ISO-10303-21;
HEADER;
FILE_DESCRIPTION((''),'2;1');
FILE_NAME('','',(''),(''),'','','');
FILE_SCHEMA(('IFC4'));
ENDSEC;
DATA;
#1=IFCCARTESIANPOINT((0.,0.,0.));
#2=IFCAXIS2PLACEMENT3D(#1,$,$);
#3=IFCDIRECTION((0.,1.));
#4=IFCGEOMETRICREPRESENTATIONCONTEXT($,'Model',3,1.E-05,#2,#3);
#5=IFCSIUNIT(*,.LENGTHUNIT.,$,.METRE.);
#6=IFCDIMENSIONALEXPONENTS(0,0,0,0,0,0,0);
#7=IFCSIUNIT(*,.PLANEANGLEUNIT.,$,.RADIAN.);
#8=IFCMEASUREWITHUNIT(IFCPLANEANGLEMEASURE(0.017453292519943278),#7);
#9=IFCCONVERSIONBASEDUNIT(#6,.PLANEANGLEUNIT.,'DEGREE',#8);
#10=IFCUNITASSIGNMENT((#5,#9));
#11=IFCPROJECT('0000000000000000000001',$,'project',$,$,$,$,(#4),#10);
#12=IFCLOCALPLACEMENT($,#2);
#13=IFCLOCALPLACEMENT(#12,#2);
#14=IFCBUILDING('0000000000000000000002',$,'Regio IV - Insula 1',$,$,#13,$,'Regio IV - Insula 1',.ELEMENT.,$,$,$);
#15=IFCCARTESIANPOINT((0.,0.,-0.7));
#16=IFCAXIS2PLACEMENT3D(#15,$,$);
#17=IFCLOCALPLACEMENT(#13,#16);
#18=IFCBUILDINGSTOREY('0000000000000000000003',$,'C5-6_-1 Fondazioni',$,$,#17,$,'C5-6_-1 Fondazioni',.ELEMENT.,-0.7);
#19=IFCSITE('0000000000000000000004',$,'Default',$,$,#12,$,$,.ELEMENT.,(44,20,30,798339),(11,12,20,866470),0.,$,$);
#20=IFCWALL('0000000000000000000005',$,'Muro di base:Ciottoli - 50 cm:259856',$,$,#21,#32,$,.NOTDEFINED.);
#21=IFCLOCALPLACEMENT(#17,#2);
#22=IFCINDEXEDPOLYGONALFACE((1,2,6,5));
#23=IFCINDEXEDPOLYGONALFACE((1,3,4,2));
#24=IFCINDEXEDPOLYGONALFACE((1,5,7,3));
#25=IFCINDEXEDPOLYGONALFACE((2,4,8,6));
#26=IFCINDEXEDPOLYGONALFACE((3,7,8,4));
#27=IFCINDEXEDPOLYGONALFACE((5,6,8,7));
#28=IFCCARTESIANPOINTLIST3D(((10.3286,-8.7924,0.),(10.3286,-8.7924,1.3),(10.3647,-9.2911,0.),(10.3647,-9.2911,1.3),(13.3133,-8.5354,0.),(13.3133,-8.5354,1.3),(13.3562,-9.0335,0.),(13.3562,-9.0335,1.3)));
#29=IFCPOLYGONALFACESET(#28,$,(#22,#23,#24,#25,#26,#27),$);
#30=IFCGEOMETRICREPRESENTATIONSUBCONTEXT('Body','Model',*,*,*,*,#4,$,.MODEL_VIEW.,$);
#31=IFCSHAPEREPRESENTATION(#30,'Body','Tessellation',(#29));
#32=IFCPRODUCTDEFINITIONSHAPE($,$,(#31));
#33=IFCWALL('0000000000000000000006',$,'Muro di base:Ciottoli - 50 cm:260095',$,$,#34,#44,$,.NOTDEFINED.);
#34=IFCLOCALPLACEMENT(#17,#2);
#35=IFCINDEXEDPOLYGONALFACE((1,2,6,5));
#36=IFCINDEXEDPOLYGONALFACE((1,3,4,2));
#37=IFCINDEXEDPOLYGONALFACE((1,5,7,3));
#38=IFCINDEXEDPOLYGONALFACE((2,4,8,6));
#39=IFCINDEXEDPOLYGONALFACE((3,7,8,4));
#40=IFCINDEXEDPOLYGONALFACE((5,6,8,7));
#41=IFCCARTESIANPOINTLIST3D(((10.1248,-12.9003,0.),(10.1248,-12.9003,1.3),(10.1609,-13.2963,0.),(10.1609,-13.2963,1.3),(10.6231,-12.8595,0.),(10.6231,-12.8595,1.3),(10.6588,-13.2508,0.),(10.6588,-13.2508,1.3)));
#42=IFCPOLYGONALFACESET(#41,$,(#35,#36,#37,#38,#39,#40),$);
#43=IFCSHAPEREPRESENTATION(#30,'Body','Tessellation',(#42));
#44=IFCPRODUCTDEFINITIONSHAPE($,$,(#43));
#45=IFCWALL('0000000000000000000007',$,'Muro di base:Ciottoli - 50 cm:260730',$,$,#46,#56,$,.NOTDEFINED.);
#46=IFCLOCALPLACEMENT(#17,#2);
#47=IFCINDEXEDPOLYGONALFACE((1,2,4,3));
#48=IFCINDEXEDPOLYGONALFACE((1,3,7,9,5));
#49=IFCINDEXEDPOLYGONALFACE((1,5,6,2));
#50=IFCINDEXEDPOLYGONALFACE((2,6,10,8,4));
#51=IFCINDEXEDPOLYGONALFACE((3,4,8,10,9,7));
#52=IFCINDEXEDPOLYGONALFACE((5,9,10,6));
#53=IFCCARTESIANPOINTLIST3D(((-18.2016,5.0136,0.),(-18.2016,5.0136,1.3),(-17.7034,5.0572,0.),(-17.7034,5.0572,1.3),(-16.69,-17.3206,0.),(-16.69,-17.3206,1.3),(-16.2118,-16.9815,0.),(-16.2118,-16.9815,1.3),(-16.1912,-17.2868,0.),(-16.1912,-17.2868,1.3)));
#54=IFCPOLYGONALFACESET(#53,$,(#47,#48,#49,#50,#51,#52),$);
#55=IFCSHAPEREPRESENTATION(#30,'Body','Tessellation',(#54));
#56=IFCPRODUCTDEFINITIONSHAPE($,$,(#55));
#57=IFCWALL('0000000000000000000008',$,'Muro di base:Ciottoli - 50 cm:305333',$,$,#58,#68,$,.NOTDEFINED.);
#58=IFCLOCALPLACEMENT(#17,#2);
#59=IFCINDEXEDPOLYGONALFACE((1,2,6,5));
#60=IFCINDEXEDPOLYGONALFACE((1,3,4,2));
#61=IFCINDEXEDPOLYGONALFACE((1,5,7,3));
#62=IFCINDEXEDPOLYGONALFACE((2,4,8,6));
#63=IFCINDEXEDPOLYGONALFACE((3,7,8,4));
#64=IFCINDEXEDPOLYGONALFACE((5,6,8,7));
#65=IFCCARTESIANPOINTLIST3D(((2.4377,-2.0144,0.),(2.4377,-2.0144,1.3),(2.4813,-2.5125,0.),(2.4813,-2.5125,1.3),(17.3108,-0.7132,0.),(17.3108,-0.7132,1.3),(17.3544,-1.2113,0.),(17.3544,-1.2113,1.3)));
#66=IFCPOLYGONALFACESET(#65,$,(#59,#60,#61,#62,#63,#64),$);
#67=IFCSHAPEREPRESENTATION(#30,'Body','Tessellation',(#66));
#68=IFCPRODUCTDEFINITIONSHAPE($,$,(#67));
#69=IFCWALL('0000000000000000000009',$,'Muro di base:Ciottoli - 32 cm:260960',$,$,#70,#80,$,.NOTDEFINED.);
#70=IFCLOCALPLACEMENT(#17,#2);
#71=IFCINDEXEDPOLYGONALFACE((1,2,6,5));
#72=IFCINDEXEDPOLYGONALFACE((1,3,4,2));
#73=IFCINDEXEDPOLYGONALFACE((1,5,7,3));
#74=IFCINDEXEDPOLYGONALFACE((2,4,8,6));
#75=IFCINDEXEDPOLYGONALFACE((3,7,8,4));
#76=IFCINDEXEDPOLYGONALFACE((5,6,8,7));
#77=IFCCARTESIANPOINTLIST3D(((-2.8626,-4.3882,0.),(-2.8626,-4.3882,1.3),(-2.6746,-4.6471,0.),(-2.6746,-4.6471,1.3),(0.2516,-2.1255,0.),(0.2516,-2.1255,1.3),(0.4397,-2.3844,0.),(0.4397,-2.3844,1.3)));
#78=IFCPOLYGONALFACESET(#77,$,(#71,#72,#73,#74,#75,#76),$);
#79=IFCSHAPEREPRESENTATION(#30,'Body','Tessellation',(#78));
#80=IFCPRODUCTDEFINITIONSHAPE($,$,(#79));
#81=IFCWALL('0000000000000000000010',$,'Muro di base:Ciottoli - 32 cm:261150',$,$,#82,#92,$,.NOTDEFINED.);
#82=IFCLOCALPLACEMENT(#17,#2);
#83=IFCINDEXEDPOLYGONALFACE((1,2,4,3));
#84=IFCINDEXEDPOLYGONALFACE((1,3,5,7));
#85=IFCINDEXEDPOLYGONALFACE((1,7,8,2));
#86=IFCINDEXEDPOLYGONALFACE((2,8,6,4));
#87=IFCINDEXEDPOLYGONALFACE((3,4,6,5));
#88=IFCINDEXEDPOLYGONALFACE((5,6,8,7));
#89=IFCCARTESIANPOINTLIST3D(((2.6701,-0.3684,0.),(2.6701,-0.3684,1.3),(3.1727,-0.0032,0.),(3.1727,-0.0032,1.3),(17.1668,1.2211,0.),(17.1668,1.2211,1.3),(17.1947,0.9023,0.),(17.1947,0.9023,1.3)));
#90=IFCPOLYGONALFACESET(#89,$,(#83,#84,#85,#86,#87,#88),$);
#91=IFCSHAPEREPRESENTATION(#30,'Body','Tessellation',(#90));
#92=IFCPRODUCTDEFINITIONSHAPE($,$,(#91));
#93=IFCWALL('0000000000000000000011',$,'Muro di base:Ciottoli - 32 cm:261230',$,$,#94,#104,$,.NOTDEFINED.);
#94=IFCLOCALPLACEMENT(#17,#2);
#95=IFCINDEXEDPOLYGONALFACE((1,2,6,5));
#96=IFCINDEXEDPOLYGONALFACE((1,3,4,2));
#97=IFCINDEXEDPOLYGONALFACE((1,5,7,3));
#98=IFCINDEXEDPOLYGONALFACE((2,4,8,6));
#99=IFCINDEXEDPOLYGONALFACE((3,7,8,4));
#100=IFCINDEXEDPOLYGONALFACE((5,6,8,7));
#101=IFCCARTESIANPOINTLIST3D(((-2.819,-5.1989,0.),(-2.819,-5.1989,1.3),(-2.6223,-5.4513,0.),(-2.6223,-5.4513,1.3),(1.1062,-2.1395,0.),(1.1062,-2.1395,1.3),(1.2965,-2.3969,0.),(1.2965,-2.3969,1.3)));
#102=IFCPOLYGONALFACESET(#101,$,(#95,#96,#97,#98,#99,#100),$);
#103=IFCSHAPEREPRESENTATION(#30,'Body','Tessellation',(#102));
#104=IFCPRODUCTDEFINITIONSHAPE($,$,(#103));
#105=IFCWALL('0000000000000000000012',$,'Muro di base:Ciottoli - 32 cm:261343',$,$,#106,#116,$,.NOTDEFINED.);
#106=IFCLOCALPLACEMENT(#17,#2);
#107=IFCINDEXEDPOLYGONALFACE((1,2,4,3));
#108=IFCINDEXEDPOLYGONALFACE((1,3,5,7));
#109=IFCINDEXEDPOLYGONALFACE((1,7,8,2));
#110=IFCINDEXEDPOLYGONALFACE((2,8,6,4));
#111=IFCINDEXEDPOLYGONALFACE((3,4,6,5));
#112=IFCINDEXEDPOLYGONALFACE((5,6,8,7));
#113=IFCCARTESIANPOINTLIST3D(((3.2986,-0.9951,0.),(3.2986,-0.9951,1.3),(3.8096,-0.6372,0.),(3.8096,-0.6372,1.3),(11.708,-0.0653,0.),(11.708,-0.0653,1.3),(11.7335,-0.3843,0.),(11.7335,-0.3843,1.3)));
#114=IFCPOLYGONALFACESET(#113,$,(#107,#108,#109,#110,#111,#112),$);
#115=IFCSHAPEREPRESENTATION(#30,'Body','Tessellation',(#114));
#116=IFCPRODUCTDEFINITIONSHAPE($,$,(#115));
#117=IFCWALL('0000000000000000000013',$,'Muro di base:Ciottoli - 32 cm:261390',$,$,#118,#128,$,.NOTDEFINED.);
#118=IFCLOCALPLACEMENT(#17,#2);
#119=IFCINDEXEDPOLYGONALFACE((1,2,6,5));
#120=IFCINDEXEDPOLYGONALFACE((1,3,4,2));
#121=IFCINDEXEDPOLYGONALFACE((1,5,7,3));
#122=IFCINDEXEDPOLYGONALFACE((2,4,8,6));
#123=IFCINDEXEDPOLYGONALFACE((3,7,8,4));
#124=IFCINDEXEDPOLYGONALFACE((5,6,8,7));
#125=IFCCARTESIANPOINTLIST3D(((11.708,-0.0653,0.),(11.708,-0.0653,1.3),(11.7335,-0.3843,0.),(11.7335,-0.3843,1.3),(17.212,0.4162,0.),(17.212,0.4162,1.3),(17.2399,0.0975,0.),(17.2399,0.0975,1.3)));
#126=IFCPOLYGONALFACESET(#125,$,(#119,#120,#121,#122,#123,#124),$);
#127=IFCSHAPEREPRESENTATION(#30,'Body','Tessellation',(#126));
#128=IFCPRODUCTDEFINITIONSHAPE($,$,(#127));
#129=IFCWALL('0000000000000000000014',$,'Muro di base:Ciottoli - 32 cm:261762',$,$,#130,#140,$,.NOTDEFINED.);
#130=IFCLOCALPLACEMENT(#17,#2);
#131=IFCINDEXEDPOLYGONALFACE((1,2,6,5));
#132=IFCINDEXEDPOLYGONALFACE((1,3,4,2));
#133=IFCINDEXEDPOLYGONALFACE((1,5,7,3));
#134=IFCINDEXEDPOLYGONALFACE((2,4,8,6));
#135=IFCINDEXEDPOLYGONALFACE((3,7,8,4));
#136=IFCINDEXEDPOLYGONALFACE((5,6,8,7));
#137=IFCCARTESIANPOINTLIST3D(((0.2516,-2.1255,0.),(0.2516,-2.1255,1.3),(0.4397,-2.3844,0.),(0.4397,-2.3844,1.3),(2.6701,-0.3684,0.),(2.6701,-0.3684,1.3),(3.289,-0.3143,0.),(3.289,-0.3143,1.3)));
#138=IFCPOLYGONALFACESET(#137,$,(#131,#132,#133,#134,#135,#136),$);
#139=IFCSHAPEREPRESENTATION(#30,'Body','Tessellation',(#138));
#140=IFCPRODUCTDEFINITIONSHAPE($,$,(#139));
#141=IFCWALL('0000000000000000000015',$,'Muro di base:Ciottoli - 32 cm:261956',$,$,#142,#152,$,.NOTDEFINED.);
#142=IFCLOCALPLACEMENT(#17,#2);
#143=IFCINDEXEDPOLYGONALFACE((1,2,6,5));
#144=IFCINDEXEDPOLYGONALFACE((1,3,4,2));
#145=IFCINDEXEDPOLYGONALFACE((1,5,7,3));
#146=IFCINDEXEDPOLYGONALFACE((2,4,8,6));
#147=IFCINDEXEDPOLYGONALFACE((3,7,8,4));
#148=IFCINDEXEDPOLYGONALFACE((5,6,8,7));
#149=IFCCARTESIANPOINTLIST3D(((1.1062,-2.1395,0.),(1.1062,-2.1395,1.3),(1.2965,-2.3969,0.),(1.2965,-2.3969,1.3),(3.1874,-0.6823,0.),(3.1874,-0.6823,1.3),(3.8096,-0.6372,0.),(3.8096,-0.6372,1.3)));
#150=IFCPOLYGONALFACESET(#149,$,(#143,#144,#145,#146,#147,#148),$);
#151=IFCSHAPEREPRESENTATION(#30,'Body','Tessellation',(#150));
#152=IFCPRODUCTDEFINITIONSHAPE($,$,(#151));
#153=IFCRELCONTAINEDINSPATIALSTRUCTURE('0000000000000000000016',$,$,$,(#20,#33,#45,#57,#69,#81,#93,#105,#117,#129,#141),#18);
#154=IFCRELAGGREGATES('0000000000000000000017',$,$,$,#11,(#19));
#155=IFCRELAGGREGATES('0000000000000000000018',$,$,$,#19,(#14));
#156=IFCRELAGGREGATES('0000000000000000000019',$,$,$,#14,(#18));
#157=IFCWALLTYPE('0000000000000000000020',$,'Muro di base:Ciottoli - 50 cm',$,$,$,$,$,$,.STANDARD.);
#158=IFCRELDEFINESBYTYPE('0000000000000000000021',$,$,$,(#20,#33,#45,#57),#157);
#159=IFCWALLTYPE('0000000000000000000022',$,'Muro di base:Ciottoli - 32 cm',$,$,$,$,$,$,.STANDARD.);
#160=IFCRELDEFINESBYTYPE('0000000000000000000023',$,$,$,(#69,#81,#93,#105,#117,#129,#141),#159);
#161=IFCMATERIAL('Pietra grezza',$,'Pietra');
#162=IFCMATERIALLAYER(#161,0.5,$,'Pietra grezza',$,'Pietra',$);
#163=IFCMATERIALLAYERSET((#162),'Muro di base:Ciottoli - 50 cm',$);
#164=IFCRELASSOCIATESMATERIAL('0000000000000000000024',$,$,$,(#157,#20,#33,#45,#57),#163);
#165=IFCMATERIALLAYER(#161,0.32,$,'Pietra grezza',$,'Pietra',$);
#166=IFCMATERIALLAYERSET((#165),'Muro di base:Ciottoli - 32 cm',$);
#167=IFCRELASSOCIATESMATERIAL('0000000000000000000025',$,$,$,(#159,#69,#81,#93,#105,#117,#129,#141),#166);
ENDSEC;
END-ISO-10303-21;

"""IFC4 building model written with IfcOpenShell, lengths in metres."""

from ifc_helpers import new_model, entity, si_unit, converted_unit, direction, frame, frame_2d, origin, place, context, subcontext, project, spatial, polyline, rectangle, outline, extrude, material, layer, layer_set, layer_usage, type_object, element, save


model = new_model("IFC4")

# Units and contexts
model_context = context("Model", 3, precision=1e-05, world=origin(), true_north=direction((0.0, 1.0)))
body_context = subcontext(model_context, "Body", "Model", "MODEL_VIEW")
ifc_project = project(units=[si_unit("LENGTHUNIT", "METRE"), converted_unit("PLANEANGLEUNIT", "DEGREE", entity("IfcPlaneAngleMeasure", 0.017453292519943278), si_unit("PLANEANGLEUNIT", "RADIAN"), dimensions=[0, 0, 0, 0, 0, 0, 0])], contexts=[model_context])

# Site, building, storey
site_placement = place(None, origin())
site = spatial("IfcSite", under=ifc_project, at=site_placement, Name="Default", CompositionType="ELEMENT", RefLatitude=(44, 20, 30, 798339), RefLongitude=(11, 12, 20, 866470), RefElevation=0.0)
building_placement = place(site_placement, origin())
building = spatial("IfcBuilding", under=site, at=building_placement, Name="Regio IV - Insula 1", LongName="Regio IV - Insula 1", CompositionType="ELEMENT")
storey_placement = place(building_placement, frame((0.0, 0.0, -0.7)))
storey = spatial("IfcBuildingStorey", under=building, at=storey_placement, Name="C5-6_-1 Fondazioni", LongName="C5-6_-1 Fondazioni", CompositionType="ELEMENT", Elevation=-0.7)

# Walls
ifc_material = material(Name="Pietra grezza", Category="Pietra")
ifc_layer_1 = layer(ifc_material, 0.5, Name="Pietra grezza", Category="Pietra")
ifc_layer_set_1 = layer_set([ifc_layer_1], Name="Muro di base:Ciottoli - 50 cm")
wall_type_1 = type_object("IfcWallType", Name="Muro di base:Ciottoli - 50 cm", PredefinedType="STANDARD", material=ifc_layer_set_1)
ifc_layer_usage_1 = layer_usage(ifc_layer_set_1, "AXIS2", "NEGATIVE", 0.25)
wall_1_placement = place(storey_placement, frame((13.3348, -8.7844, 0.0), z_axis=(0.0, 0.0, 1.0), x_axis=(-0.996312, -0.085801, 0.0)))
element("IfcWall", 1, at=wall_1_placement, inside=storey, type_object=wall_type_1, material=ifc_layer_usage_1, Name="Muro di base:Ciottoli - 50 cm:259856", PredefinedType="NOTDEFINED", context=body_context, shape_type="SweptSolid", body=[
    extrude(outline(polyline([(2.9957, -0.25), (3.0026, 0.25), (0.0, 0.25), (0.0, -0.25), (2.9957, -0.25)])), origin(), (0.0, 0.0, 1.0), 1.3),
])
ifc_layer_usage_2 = layer_usage(ifc_layer_set_1, "AXIS2", "NEGATIVE", 0.25)
wall_2_placement = place(storey_placement, frame((10.3737, -12.8776, 0.0), z_axis=(0.0, 0.0, 1.0), x_axis=(0.090941, -0.995856, 0.0)))
element("IfcWall", 2, at=wall_2_placement, inside=storey, type_object=wall_type_1, material=ifc_layer_usage_2, Name="Muro di base:Ciottoli - 50 cm:260095", PredefinedType="NOTDEFINED", context=body_context, shape_type="SweptSolid", body=[
    extrude(outline(polyline([(0.3976, -0.25), (0.3976, 0.25), (0.0047, 0.25), (0.0, -0.25), (0.3976, -0.25)])), origin(), (0.0, 0.0, 1.0), 1.3),
])
ifc_layer_usage_3 = layer_usage(ifc_layer_set_1, "AXIS2", "NEGATIVE", 0.25)
wall_3_placement = place(storey_placement, frame((-17.9528, 5.0403, 0.0), z_axis=(0.0, 0.0, 1.0), x_axis=(0.067526, -0.997718, 0.0)))
element("IfcWall", 3, at=wall_3_placement, inside=storey, type_object=wall_type_1, material=ifc_layer_usage_3, Name="Muro di base:Ciottoli - 50 cm:260730", PredefinedType="NOTDEFINED", context=body_context, shape_type="SweptSolid", body=[
    extrude(outline(polyline([(22.3951, -0.25), (22.3951, 0.25), (22.0892, 0.25), (0.0, 0.25), (0.0098, -0.25), (22.3951, -0.25)])), origin(), (0.0, 0.0, 1.0), 1.3),
])
ifc_layer_usage_4 = layer_usage(ifc_layer_set_1, "AXIS2", "NEGATIVE", 0.25)
wall_4_placement = place(storey_placement, frame((2.4595, -2.2635, 0.0), z_axis=(0.0, 0.0, 1.0), x_axis=(0.996195, 0.087156, 0.0)))
element("IfcWall", 4, at=wall_4_placement, inside=storey, type_object=wall_type_1, material=ifc_layer_usage_4, Name="Muro di base:Ciottoli - 50 cm:305333", PredefinedType="NOTDEFINED", context=body_context, shape_type="SweptSolid", body=[
    extrude(rectangle(XDim=14.93, YDim=0.5, at=frame_2d((7.465, 0.0), x_axis=(-1.0, 0.0))), origin(), (0.0, 0.0, 1.0), 1.3),
])
ifc_layer_2 = layer(ifc_material, 0.32, Name="Pietra grezza", Category="Pietra")
ifc_layer_set_2 = layer_set([ifc_layer_2], Name="Muro di base:Ciottoli - 32 cm")
ifc_layer_usage_5 = layer_usage(ifc_layer_set_2, "AXIS2", "NEGATIVE", 0.16)
wall_type_2 = type_object("IfcWallType", Name="Muro di base:Ciottoli - 32 cm", PredefinedType="STANDARD", material=ifc_layer_set_2)
wall_5_placement = place(storey_placement, frame((-2.7686, -4.5176, 0.0), z_axis=(0.0, 0.0, 1.0), x_axis=(0.809017, 0.587785, 0.0)))
element("IfcWall", 5, at=wall_5_placement, inside=storey, type_object=wall_type_2, material=ifc_layer_usage_5, Name="Muro di base:Ciottoli - 32 cm:260960", PredefinedType="NOTDEFINED", context=body_context, shape_type="SweptSolid", body=[
    extrude(rectangle(XDim=3.8494, YDim=0.32, at=frame_2d((1.9247, 0.0), x_axis=(-1.0, 0.0))), origin(), (0.0, 0.0, 1.0), 1.3),
])
ifc_layer_usage_6 = layer_usage(ifc_layer_set_2, "AXIS2", "NEGATIVE", 0.16)
wall_6_placement = place(storey_placement, frame((2.6561, -0.2091, 0.0), z_axis=(0.0, 0.0, 1.0), x_axis=(0.996195, 0.087156, 0.0)))
element("IfcWall", 6, at=wall_6_placement, inside=storey, type_object=wall_type_2, material=ifc_layer_usage_6, Name="Muro di base:Ciottoli - 32 cm:261150", PredefinedType="NOTDEFINED", context=body_context, shape_type="SweptSolid", body=[
    extrude(outline(polyline([(14.5801, -0.16), (14.5801, 0.16), (0.5326, 0.16), (0.0, -0.16), (14.5801, -0.16)])), origin(), (0.0, 0.0, 1.0), 1.3),
])
ifc_layer_usage_7 = layer_usage(ifc_layer_set_2, "AXIS2", "NEGATIVE", 0.16)
wall_7_placement = place(storey_placement, frame((-2.7206, -5.3251, 0.0), z_axis=(0.0, 0.0, 1.0), x_axis=(0.78872, 0.614752, 0.0)))
element("IfcWall", 7, at=wall_7_placement, inside=storey, type_object=wall_type_2, material=ifc_layer_usage_7, Name="Muro di base:Ciottoli - 32 cm:261230", PredefinedType="NOTDEFINED", context=body_context, shape_type="SweptSolid", body=[
    extrude(outline(polyline([(4.9685, -0.16), (4.9767, 0.16), (0.0, 0.16), (0.0, -0.16), (4.9685, -0.16)])), origin(), (0.0, 0.0, 1.0), 1.3),
])
ifc_layer_usage_8 = layer_usage(ifc_layer_set_2, "AXIS2", "NEGATIVE", 0.16)
wall_8_placement = place(storey_placement, frame((3.287, -0.8355, 0.0), z_axis=(0.0, 0.0, 1.0), x_axis=(0.997389, 0.07222, 0.0)))
element("IfcWall", 8, at=wall_8_placement, inside=storey, type_object=wall_type_2, material=ifc_layer_usage_8, Name="Muro di base:Ciottoli - 32 cm:261343", PredefinedType="NOTDEFINED", context=body_context, shape_type="SweptSolid", body=[
    extrude(outline(polyline([(8.457, -0.16), (8.4546, 0.16), (0.5356, 0.16), (0.0, -0.16), (8.457, -0.16)])), origin(), (0.0, 0.0, 1.0), 1.3),
])
ifc_layer_usage_9 = layer_usage(ifc_layer_set_2, "AXIS2", "NEGATIVE", 0.16)
wall_9_placement = place(storey_placement, frame((11.7196, -0.2249, 0.0), z_axis=(0.0, 0.0, 1.0), x_axis=(0.996195, 0.087156, 0.0)))
element("IfcWall", 9, at=wall_9_placement, inside=storey, type_object=wall_type_2, material=ifc_layer_usage_9, Name="Muro di base:Ciottoli - 32 cm:261390", PredefinedType="NOTDEFINED", context=body_context, shape_type="SweptSolid", body=[
    extrude(outline(polyline([(5.5274, -0.16), (5.5274, 0.16), (0.0024, 0.16), (0.0, -0.16), (5.5274, -0.16)])), origin(), (0.0, 0.0, 1.0), 1.3),
])
ifc_layer_usage_10 = layer_usage(ifc_layer_set_2, "AXIS2", "NEGATIVE", 0.16)
wall_10_placement = place(storey_placement, frame((0.3457, -2.255, 0.0), z_axis=(0.0, 0.0, 1.0), x_axis=(0.809017, 0.587785, 0.0)))
element("IfcWall", 10, at=wall_10_placement, inside=storey, type_object=wall_type_2, material=ifc_layer_usage_10, Name="Muro di base:Ciottoli - 32 cm:261762", PredefinedType="NOTDEFINED", context=body_context, shape_type="SweptSolid", body=[
    extrude(outline(polyline([(3.5219, -0.16), (2.9893, 0.16), (0.0, 0.16), (0.0, -0.16), (3.5219, -0.16)])), origin(), (0.0, 0.0, 1.0), 1.3),
])
ifc_layer_usage_11 = layer_usage(ifc_layer_set_2, "AXIS2", "NEGATIVE", 0.16)
wall_11_placement = place(storey_placement, frame((1.198, -2.2706, 0.0), z_axis=(0.0, 0.0, 1.0), x_axis=(0.819152, 0.573576, 0.0)))
element("IfcWall", 11, at=wall_11_placement, inside=storey, type_object=wall_type_2, material=ifc_layer_usage_11, Name="Muro di base:Ciottoli - 32 cm:261956", PredefinedType="NOTDEFINED", context=body_context, shape_type="SweptSolid", body=[
    extrude(outline(polyline([(3.0762, -0.16), (2.5406, 0.16), (0.0, 0.16), (0.0082, -0.16), (3.0762, -0.16)])), origin(), (0.0, 0.0, 1.0), 1.3),
])

save(model, "model.ifc")
